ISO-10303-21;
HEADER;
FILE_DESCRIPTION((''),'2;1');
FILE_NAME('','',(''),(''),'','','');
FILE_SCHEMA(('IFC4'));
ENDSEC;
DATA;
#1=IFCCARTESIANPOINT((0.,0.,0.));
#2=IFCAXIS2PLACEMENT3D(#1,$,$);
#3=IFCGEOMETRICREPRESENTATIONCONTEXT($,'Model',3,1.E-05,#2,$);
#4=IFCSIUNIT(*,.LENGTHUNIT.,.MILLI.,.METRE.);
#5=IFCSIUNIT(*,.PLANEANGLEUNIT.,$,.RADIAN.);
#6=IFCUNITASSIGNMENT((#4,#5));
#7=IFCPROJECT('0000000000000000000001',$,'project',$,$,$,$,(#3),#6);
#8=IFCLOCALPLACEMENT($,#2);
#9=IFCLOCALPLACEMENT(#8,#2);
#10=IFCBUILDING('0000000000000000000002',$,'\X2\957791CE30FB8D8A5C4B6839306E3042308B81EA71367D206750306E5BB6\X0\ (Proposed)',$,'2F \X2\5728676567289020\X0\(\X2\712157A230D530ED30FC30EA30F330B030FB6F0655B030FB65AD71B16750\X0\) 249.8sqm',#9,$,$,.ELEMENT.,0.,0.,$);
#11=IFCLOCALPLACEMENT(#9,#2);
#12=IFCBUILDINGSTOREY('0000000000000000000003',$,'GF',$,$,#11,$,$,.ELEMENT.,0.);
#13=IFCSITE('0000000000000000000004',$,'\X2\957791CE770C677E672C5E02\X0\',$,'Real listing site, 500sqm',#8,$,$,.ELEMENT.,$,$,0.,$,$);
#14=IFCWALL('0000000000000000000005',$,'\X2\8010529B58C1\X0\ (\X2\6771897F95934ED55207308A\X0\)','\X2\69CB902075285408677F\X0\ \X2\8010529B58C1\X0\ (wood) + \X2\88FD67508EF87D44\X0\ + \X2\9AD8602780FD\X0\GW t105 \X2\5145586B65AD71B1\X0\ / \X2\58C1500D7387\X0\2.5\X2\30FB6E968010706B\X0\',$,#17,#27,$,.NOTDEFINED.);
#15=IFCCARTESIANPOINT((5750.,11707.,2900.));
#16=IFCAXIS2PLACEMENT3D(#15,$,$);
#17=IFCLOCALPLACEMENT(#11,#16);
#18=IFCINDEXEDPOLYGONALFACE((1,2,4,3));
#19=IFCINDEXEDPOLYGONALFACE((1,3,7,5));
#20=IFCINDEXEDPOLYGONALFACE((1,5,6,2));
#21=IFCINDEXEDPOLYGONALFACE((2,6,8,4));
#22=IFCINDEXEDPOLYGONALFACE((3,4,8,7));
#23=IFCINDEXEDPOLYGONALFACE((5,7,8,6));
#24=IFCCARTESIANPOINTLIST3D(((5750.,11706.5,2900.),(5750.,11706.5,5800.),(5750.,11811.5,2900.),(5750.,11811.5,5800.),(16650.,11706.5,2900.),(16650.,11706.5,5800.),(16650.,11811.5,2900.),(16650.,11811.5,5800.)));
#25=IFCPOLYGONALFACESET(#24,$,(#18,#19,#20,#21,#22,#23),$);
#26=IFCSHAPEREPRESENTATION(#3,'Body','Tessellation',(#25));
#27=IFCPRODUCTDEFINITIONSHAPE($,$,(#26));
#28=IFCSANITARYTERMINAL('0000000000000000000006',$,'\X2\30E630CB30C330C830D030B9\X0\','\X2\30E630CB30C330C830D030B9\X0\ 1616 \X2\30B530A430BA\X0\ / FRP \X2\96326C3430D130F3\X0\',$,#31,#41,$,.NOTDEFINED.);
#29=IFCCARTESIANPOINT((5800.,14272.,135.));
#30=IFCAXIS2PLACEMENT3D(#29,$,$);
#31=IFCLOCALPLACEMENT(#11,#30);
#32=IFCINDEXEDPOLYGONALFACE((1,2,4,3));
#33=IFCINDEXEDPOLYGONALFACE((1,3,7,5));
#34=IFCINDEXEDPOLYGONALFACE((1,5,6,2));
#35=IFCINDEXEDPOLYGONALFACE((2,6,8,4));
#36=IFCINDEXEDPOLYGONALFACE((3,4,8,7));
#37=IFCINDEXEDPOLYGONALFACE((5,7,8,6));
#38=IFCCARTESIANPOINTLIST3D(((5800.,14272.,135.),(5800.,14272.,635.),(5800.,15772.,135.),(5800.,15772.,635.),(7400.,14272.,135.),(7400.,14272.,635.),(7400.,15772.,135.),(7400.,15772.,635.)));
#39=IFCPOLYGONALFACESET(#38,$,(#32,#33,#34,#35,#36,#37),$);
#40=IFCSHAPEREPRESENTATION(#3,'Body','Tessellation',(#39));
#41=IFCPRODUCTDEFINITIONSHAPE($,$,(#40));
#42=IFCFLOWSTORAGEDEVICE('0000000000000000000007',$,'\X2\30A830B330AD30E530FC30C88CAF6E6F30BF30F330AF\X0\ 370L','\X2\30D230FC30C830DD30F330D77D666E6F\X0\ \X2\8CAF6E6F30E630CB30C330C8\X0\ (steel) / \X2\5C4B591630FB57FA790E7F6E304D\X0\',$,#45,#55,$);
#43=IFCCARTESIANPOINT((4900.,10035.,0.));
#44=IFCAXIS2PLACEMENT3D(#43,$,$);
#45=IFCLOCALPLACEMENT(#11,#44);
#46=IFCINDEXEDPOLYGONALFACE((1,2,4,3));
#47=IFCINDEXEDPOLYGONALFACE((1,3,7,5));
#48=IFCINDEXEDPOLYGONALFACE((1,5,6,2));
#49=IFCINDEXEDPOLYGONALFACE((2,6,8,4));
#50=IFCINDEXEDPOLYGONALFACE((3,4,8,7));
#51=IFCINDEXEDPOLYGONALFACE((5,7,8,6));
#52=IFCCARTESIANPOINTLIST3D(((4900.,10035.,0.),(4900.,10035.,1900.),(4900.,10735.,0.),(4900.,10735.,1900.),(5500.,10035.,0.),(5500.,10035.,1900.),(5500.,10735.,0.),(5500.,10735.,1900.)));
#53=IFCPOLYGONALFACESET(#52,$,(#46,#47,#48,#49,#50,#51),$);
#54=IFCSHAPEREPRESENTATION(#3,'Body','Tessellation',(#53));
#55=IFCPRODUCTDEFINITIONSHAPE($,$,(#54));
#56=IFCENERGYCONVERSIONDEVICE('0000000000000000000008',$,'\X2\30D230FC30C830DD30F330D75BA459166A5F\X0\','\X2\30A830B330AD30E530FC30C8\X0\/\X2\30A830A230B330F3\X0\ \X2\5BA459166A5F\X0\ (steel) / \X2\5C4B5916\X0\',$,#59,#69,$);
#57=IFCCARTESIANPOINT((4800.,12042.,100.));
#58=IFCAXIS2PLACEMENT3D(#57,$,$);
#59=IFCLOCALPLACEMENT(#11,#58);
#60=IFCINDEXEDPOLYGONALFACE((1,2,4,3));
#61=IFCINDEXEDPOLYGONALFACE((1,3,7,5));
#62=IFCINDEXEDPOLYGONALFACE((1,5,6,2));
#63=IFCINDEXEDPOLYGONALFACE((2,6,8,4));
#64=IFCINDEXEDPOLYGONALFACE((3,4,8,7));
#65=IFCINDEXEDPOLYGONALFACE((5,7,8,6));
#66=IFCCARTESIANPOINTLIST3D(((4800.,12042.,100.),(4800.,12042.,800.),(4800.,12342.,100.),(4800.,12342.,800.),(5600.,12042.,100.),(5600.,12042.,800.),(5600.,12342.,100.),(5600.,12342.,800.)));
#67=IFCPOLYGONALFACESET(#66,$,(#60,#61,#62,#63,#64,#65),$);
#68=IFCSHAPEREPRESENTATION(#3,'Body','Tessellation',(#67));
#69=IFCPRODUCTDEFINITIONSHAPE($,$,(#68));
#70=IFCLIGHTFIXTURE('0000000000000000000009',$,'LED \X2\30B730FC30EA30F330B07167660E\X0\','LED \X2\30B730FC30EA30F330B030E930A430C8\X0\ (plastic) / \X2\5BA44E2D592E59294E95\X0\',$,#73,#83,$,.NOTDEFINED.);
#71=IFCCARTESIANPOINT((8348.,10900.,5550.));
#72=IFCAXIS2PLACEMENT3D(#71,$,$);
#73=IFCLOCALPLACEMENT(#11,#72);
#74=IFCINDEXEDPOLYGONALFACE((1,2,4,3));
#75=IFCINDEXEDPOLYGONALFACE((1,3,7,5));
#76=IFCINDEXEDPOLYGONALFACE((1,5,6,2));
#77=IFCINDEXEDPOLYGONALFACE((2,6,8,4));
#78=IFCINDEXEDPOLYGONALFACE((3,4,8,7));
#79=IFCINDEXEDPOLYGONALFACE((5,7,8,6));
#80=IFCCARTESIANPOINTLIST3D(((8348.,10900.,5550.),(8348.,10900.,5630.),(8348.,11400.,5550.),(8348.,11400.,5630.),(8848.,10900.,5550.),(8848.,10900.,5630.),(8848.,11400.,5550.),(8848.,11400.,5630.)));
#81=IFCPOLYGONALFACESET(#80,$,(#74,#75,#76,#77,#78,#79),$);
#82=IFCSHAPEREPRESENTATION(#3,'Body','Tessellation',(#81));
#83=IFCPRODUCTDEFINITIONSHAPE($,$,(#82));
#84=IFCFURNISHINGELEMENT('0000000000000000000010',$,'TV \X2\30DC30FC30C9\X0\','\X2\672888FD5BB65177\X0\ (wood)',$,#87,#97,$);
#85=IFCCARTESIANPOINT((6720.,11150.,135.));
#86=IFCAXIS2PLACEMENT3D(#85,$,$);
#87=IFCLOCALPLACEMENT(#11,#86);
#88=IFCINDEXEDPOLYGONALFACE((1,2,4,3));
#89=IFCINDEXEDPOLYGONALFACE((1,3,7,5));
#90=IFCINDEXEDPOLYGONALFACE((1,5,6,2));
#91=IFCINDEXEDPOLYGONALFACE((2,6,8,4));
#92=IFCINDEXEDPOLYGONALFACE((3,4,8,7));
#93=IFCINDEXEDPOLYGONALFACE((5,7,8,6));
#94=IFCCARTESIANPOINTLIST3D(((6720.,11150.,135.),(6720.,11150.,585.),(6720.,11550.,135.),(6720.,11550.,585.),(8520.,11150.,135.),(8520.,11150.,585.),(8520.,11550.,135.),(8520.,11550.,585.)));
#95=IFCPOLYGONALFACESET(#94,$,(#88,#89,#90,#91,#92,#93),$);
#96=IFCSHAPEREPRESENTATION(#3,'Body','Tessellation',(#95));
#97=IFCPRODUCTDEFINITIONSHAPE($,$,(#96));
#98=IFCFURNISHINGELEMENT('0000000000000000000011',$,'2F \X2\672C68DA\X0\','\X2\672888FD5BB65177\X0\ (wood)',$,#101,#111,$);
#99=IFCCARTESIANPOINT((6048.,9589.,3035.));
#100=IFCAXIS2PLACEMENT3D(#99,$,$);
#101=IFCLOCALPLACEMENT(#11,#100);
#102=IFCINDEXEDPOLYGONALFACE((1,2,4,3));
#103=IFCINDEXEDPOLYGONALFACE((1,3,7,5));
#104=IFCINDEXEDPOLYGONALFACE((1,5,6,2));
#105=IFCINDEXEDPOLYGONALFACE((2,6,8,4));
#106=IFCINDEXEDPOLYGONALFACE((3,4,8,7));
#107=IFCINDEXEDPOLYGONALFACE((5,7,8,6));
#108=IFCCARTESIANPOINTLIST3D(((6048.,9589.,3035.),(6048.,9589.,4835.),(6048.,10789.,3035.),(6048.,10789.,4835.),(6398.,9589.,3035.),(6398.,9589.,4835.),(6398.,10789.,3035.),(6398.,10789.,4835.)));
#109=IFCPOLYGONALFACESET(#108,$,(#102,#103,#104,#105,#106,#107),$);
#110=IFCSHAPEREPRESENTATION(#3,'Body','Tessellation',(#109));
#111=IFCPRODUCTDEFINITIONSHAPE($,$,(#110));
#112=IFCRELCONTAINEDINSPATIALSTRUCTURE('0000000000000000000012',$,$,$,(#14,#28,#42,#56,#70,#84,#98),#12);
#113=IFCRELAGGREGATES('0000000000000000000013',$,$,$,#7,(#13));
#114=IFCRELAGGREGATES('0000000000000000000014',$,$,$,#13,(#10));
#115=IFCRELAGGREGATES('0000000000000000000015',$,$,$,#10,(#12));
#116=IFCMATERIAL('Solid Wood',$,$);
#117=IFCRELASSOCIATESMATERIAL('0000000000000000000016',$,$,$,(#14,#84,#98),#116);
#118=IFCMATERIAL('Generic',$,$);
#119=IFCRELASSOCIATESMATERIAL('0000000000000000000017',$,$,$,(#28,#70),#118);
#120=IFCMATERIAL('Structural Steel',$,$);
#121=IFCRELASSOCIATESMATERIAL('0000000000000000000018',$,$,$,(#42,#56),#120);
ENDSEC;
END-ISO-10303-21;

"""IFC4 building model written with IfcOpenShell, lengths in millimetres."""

from ifc_helpers import new_model, si_unit, frame, frame_2d, origin, place, context, project, spatial, rectangle, extrude, material, element, save


model = new_model("IFC4")

# Units and contexts
model_context = context("Model", 3, precision=1e-05, world=origin())
ifc_project = project(units=[si_unit("LENGTHUNIT", "METRE", prefix="MILLI"), si_unit("PLANEANGLEUNIT", "RADIAN")], contexts=[model_context])

# Site, building, storey
site_placement = place(None, origin())
site = spatial("IfcSite", under=ifc_project, at=site_placement, Name="長野県松本市", ObjectType="Real listing site, 500sqm", CompositionType="ELEMENT", RefElevation=0.0)
building_placement = place(site_placement, origin())
building = spatial("IfcBuilding", under=site, at=building_placement, Name="長野・越屋根のある自然素材の家 (Proposed)", ObjectType="2F 在来木造(無垢フローリング・漆喰・断熱材) 249.8sqm", CompositionType="ELEMENT", ElevationOfRefHeight=0.0, ElevationOfTerrain=0.0)
storey_placement = place(building_placement, origin())
storey = spatial("IfcBuildingStorey", under=building, at=storey_placement, Name="GF", CompositionType="ELEMENT", Elevation=0.0)

# Shared definitions
ifc_material_1 = material(Name="Solid Wood")

# Wall
wall_1_placement = place(storey_placement, frame((5750.0, 11707.0, 2900.0)))
element("IfcWall", 1, at=wall_1_placement, inside=storey, material=ifc_material_1, Name="耐力壁 (東西間仕切り)", Description="構造用合板 耐力壁 (wood) + 製材軸組 + 高性能GW t105 充填断熱 / 壁倍率2.5・準耐火", PredefinedType="NOTDEFINED", context=model_context, shape_type="SweptSolid", body=[
    extrude(rectangle(XDim=10900.0, YDim=105.0, at=frame_2d((5450.0, 52.0))), frame((5750.0, 11707.0, 2900.0)), (0.0, 0.0, 1.0), 2900.0),
])

# Sanitary terminal
ifc_material_2 = material(Name="Generic")
sanitary_terminal_placement = place(storey_placement, frame((5800.0, 14272.0, 135.0)))
element("IfcSanitaryTerminal", 2, at=sanitary_terminal_placement, inside=storey, material=ifc_material_2, Name="ユニットバス", Description="ユニットバス 1616 サイズ / FRP 防水パン", PredefinedType="NOTDEFINED", context=model_context, shape_type="SweptSolid", body=[
    extrude(rectangle(XDim=1600.0, YDim=1500.0, at=frame_2d((800.0, 750.0))), frame((5800.0, 14272.0, 135.0)), (0.0, 0.0, 1.0), 500.0),
])

# Flow storage device
ifc_material_3 = material(Name="Structural Steel")
flow_storage_device_placement = place(storey_placement, frame((4900.0, 10035.0, 0.0)))
element("IfcFlowStorageDevice", 3, at=flow_storage_device_placement, inside=storey, material=ifc_material_3, Name="エコキュート貯湯タンク 370L", Description="ヒートポンプ給湯 貯湯ユニット (steel) / 屋外・基礎置き", context=model_context, shape_type="SweptSolid", body=[
    extrude(rectangle(XDim=600.0, YDim=700.0, at=frame_2d((300.0, 350.0))), frame((4900.0, 10035.0, 0.0)), (0.0, 0.0, 1.0), 1900.0),
])

# Energy conversion device
energy_conversion_device_placement = place(storey_placement, frame((4800.0, 12042.0, 100.0)))
element("IfcEnergyConversionDevice", 4, at=energy_conversion_device_placement, inside=storey, material=ifc_material_3, Name="ヒートポンプ室外機", Description="エコキュート/エアコン 室外機 (steel) / 屋外", context=model_context, shape_type="SweptSolid", body=[
    extrude(rectangle(XDim=800.0, YDim=300.0, at=frame_2d((400.0, 150.0))), frame((4800.0, 12042.0, 100.0)), (0.0, 0.0, 1.0), 700.0),
])

# Light fixture
light_fixture_placement = place(storey_placement, frame((8348.0, 10900.0, 5550.0)))
element("IfcLightFixture", 5, at=light_fixture_placement, inside=storey, material=ifc_material_2, Name="LED シーリング照明", Description="LED シーリングライト (plastic) / 室中央天井", PredefinedType="NOTDEFINED", context=model_context, shape_type="SweptSolid", body=[
    extrude(rectangle(XDim=500.0, YDim=500.0, at=frame_2d((250.0, 250.0))), frame((8348.0, 10900.0, 5550.0)), (0.0, 0.0, 1.0), 80.0),
])

# Furnishing elements
furnishing_1_placement = place(storey_placement, frame((6720.0, 11150.0, 135.0)))
element("IfcFurnishingElement", 6, at=furnishing_1_placement, inside=storey, material=ifc_material_1, Name="TV ボード", Description="木製家具 (wood)", context=model_context, shape_type="SweptSolid", body=[
    extrude(rectangle(XDim=1800.0, YDim=400.0, at=frame_2d((900.0, 200.0))), frame((6720.0, 11150.0, 135.0)), (0.0, 0.0, 1.0), 450.0),
])
furnishing_2_placement = place(storey_placement, frame((6048.0, 9589.0, 3035.0)))
element("IfcFurnishingElement", 7, at=furnishing_2_placement, inside=storey, material=ifc_material_1, Name="2F 本棚", Description="木製家具 (wood)", context=model_context, shape_type="SweptSolid", body=[
    extrude(rectangle(XDim=350.0, YDim=1200.0, at=frame_2d((175.0, 600.0))), frame((6048.0, 9589.0, 3035.0)), (0.0, 0.0, 1.0), 1800.0),
])

save(model, "model.ifc")
